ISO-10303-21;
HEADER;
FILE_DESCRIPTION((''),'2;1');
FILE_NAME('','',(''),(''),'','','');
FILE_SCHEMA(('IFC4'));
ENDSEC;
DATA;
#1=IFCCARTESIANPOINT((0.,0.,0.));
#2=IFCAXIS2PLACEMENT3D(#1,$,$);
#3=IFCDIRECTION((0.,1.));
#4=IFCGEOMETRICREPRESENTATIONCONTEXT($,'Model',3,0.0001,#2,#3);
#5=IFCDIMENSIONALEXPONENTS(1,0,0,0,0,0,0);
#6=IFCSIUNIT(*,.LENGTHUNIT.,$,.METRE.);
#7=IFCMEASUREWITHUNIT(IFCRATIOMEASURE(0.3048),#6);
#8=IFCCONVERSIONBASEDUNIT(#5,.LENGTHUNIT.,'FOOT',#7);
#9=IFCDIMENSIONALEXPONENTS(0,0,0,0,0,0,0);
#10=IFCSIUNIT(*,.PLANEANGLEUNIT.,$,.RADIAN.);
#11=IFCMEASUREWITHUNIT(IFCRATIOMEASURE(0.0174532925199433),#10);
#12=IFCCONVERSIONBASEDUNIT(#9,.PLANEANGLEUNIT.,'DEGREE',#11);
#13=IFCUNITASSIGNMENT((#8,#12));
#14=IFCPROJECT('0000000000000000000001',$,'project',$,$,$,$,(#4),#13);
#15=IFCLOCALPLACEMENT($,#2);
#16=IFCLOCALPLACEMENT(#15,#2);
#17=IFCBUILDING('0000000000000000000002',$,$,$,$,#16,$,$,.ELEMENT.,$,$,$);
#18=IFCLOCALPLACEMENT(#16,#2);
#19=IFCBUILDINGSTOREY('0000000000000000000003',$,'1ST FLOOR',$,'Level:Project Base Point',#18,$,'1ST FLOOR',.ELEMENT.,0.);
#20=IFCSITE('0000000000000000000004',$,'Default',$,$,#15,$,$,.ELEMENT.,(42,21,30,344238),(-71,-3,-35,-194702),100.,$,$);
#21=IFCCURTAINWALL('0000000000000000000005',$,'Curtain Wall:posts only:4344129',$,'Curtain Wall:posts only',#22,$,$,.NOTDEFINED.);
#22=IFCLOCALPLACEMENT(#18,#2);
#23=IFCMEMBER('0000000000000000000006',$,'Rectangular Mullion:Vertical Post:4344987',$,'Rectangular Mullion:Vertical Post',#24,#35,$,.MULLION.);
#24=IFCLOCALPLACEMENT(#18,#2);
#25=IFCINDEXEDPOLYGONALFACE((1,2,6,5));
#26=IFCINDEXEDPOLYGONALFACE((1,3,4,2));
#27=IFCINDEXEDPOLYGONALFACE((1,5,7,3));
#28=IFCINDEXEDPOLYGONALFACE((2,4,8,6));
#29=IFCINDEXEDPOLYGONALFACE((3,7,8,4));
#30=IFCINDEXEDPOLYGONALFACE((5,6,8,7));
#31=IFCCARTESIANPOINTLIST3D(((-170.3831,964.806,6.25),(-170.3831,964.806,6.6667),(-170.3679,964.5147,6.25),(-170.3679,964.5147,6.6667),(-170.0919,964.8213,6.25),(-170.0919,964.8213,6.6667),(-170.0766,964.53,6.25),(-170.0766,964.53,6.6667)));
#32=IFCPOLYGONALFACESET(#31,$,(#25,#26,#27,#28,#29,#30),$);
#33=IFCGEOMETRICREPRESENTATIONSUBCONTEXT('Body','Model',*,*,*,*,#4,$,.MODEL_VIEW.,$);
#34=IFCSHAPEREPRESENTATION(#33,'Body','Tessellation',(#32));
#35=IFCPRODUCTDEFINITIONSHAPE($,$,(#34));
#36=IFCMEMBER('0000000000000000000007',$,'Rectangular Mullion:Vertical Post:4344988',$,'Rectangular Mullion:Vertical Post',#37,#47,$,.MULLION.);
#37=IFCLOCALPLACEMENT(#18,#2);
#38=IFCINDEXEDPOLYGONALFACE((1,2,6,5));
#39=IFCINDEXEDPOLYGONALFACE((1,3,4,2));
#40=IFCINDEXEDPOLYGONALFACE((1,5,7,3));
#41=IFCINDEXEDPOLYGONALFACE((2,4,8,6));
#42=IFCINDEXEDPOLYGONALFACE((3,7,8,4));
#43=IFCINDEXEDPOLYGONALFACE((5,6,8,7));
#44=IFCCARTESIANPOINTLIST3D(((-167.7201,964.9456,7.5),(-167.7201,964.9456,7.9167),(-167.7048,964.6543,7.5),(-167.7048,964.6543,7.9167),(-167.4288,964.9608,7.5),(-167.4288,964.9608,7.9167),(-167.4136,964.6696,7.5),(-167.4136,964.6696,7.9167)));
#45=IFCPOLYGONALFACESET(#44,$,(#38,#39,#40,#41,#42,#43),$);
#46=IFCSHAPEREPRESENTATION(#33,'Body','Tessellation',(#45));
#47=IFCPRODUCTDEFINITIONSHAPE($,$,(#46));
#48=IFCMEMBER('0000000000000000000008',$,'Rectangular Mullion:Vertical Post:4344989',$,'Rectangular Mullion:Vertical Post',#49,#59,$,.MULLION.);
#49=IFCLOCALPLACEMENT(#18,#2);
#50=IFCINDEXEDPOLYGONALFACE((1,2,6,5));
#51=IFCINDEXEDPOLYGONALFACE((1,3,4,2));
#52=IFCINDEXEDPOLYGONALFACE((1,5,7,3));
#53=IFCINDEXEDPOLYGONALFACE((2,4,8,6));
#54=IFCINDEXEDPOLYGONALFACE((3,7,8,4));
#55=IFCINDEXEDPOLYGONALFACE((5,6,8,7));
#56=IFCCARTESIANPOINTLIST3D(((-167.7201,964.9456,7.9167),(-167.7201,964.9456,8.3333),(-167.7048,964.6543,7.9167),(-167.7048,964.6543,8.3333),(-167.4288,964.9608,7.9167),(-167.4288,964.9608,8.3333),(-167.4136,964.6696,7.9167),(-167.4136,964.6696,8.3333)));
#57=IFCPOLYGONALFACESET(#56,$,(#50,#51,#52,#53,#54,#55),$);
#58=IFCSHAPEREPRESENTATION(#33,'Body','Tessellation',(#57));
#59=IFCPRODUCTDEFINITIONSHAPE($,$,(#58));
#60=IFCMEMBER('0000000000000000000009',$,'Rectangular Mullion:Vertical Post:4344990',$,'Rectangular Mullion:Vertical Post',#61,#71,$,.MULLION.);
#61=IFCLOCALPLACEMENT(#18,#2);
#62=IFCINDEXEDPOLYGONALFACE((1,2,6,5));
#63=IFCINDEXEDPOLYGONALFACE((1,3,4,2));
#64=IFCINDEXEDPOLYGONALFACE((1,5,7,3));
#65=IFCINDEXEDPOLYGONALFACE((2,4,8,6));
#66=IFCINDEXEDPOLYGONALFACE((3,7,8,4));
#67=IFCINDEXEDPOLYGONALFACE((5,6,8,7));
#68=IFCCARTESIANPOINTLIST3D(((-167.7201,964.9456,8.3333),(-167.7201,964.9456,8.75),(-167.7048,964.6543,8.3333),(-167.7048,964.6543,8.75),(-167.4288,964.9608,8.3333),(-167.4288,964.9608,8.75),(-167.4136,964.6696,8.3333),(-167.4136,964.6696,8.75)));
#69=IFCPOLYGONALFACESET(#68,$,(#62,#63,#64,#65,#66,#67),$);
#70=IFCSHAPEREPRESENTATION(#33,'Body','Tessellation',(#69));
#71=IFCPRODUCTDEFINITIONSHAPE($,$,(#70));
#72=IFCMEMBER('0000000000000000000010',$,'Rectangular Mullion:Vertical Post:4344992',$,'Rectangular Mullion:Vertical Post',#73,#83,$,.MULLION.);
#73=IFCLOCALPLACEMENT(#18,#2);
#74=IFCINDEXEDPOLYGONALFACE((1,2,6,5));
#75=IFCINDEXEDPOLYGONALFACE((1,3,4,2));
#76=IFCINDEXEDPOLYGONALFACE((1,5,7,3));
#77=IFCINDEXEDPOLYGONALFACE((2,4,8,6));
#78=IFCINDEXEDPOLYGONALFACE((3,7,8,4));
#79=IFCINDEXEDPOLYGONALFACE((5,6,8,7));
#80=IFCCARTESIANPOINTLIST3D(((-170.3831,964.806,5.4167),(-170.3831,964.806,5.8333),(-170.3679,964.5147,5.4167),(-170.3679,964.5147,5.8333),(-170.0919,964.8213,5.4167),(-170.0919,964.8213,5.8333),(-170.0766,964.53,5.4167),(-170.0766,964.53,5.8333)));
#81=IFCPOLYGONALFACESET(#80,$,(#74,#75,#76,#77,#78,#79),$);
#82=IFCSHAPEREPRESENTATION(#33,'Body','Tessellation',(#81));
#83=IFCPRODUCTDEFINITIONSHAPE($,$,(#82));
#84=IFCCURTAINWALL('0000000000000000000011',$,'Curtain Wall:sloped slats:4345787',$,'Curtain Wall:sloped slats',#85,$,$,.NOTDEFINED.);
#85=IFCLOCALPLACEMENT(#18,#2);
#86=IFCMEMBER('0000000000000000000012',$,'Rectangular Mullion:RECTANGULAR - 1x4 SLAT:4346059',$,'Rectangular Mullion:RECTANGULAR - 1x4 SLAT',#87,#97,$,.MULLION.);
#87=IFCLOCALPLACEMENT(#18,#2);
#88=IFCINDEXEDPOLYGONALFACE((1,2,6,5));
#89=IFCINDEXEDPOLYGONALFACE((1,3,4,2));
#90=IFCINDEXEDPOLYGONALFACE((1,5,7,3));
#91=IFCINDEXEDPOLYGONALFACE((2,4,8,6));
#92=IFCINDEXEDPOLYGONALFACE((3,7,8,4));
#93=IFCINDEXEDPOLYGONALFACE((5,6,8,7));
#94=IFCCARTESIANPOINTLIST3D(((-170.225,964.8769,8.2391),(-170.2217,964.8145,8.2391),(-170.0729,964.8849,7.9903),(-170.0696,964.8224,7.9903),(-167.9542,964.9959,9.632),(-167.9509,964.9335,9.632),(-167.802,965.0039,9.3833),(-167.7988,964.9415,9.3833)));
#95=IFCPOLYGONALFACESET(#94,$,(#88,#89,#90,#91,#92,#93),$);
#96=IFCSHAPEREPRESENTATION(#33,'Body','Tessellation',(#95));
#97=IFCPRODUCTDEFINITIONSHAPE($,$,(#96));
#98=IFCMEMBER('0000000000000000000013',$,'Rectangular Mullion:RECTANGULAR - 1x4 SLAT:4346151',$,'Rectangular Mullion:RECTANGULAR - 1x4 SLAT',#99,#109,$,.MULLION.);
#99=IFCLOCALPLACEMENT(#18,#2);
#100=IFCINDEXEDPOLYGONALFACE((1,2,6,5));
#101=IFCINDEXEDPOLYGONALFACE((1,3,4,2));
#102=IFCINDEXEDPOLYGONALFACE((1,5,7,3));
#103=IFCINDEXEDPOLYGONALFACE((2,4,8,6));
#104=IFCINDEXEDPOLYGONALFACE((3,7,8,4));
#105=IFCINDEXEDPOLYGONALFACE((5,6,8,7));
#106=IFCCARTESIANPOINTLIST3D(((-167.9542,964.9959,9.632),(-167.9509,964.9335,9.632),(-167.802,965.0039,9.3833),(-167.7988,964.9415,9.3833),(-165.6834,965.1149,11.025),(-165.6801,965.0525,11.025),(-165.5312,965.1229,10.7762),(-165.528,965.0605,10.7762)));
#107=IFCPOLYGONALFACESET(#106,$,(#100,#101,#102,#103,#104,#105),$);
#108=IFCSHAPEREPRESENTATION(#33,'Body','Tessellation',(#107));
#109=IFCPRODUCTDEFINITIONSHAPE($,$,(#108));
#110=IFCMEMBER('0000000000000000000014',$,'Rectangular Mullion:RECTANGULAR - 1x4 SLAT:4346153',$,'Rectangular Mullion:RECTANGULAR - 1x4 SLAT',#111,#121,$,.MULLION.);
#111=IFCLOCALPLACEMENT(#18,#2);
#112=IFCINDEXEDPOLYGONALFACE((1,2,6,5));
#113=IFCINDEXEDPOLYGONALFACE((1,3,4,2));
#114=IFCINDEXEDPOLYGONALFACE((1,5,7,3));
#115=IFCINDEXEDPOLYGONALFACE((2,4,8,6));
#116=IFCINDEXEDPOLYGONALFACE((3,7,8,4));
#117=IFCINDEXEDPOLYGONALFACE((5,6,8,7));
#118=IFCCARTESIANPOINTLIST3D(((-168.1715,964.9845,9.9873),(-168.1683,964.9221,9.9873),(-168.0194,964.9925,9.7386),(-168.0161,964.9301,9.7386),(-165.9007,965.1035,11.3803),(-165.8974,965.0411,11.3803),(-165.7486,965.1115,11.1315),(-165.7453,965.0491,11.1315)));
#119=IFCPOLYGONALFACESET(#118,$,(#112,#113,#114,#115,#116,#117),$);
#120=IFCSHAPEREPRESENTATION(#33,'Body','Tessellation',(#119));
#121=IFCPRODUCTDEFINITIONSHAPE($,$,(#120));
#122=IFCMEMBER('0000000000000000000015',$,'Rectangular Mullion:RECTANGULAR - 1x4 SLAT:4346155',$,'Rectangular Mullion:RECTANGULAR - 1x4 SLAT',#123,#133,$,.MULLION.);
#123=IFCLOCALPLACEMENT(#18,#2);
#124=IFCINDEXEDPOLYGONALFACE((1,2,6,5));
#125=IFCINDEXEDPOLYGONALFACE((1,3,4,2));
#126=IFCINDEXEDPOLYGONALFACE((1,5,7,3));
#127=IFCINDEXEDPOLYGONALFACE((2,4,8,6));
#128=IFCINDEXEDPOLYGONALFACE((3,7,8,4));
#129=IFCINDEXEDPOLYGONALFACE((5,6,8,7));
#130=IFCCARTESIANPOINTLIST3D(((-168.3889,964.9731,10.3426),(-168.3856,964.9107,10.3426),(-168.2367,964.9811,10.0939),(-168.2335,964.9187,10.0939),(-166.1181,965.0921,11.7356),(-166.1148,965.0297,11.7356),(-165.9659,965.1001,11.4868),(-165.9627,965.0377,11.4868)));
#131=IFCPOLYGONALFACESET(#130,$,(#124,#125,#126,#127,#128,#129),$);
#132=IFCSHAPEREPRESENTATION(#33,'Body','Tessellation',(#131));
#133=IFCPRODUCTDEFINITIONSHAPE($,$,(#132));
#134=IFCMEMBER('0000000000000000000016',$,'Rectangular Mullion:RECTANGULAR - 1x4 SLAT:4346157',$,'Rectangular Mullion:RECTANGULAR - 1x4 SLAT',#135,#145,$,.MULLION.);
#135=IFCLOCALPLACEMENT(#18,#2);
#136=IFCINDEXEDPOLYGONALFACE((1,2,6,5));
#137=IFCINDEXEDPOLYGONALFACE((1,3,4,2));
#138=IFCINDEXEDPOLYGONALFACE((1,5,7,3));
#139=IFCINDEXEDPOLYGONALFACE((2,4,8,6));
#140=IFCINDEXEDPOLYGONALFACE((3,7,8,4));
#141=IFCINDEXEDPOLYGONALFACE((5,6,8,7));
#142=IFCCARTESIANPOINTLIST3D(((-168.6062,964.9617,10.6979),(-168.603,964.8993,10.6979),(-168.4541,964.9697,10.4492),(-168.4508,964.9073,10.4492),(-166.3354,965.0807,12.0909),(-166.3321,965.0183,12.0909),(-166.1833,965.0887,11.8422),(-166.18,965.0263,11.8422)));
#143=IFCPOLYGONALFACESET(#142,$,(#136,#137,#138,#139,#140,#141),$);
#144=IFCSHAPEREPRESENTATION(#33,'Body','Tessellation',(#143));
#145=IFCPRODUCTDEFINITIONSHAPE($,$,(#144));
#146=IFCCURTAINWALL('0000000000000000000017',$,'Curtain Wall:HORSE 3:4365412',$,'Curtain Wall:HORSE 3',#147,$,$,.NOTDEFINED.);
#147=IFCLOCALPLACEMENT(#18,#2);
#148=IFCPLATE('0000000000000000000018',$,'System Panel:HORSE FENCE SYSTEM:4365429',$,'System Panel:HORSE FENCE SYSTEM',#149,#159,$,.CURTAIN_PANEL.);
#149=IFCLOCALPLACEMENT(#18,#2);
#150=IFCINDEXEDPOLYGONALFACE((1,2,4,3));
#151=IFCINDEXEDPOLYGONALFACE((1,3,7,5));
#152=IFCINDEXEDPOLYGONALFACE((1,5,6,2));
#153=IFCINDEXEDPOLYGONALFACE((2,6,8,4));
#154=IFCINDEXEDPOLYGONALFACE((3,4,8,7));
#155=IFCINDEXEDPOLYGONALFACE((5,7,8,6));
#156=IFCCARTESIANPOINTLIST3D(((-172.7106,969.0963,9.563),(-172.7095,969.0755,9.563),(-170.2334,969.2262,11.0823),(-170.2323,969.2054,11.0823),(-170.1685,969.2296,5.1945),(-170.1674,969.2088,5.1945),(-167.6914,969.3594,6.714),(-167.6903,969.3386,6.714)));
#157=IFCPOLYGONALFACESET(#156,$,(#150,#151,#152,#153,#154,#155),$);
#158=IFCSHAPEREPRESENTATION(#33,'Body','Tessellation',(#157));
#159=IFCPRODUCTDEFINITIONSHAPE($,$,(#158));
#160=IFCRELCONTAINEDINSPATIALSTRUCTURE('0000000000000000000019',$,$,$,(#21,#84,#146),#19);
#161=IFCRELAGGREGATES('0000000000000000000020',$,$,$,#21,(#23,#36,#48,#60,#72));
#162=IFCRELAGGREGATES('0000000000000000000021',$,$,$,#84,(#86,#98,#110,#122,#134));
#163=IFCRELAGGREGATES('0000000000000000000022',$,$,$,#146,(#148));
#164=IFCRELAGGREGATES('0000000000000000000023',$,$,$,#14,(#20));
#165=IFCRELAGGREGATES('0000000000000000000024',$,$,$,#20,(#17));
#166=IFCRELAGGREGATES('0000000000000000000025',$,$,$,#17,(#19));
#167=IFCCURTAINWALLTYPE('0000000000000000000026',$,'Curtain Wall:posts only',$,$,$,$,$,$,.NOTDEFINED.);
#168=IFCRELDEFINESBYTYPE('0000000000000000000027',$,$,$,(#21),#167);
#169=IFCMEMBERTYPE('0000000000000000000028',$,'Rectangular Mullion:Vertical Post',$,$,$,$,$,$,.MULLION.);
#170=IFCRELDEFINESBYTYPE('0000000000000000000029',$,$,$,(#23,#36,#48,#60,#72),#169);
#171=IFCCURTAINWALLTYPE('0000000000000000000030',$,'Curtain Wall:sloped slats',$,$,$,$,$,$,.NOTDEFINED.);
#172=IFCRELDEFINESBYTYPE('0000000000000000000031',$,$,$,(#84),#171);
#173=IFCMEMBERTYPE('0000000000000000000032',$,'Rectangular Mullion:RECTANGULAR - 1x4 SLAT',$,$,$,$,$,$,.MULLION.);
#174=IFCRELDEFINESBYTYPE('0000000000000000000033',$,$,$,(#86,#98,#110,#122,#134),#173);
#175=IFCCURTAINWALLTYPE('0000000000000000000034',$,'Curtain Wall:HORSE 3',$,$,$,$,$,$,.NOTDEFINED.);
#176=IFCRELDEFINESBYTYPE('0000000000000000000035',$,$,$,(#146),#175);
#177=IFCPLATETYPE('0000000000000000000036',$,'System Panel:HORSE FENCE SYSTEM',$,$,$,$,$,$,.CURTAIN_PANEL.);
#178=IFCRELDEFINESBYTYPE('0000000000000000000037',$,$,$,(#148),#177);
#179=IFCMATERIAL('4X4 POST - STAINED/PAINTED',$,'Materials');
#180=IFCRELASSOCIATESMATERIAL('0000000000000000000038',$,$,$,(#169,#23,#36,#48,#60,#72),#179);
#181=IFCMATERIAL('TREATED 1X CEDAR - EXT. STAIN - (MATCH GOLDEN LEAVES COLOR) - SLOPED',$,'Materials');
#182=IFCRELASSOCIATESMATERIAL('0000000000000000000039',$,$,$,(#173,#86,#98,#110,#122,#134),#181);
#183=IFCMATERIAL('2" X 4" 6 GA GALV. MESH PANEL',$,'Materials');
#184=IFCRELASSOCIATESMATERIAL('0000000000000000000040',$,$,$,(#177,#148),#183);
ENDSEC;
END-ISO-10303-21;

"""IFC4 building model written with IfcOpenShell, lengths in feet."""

from ifc_helpers import new_model, entity, si_unit, converted_unit, direction, frame, frame_2d, origin, origin_2d_with_axis, place, context, subcontext, project, spatial, polyline, rectangle, outline, extrude, source, transform, mapped, material, material_profile, profile_set, profile_usage, type_object, type_shapes, element, aggregate, save


model = new_model("IFC4")

# Units and contexts
model_context = context("Model", 3, precision=0.0001, world=origin(), true_north=direction((0.0, 1.0)))
body_context = subcontext(model_context, "Body", "Model", "MODEL_VIEW")
ifc_project = project(units=[converted_unit("LENGTHUNIT", "FOOT", entity("IfcRatioMeasure", 0.3048), si_unit("LENGTHUNIT", "METRE"), dimensions=[1, 0, 0, 0, 0, 0, 0]), converted_unit("PLANEANGLEUNIT", "DEGREE", entity("IfcRatioMeasure", 0.0174532925199433), si_unit("PLANEANGLEUNIT", "RADIAN"), dimensions=[0, 0, 0, 0, 0, 0, 0])], contexts=[model_context])

# Site, building, storey
site_placement = place(None, origin())
site = spatial("IfcSite", under=ifc_project, at=site_placement, Name="Default", CompositionType="ELEMENT", RefLatitude=(42, 21, 30, 344238), RefLongitude=(-71, -3, -35, -194702), RefElevation=100.0)
building_placement = place(site_placement, origin())
building = spatial("IfcBuilding", under=site, at=building_placement, CompositionType="ELEMENT")
storey_placement = place(building_placement, origin())
storey = spatial("IfcBuildingStorey", under=building, at=storey_placement, Name="1ST FLOOR", ObjectType="Level:Project Base Point", LongName="1ST FLOOR", CompositionType="ELEMENT", Elevation=0.0)

# Curtain walls, members
curtain_wall_type_1 = type_object("IfcCurtainWallType", Name="Curtain Wall:posts only", PredefinedType="NOTDEFINED")
curtain_wall_1_placement = place(storey_placement, origin())
curtain_wall_1 = element("IfcCurtainWall", 1, at=curtain_wall_1_placement, inside=storey, type_object=curtain_wall_type_1, Name="Curtain Wall:posts only:4344129", ObjectType="Curtain Wall:posts only", PredefinedType="NOTDEFINED")
ifc_material_1 = material(Name="4X4 POST - STAINED/PAINTED", Category="Materials")
ifc_material_profile_1 = material_profile(ifc_material_1, rectangle(XDim=0.2917, YDim=0.2917, at=origin_2d_with_axis()), Name="Vertical Post")
ifc_profile_set_1 = profile_set([ifc_material_profile_1], Name="Vertical Post")
member_type_1 = type_object("IfcMemberType", Name="Rectangular Mullion:Vertical Post", PredefinedType="MULLION", material=ifc_profile_set_1)
shared_shape_1 = source(origin(), body_context, "Body", "SweptSolid", [
    extrude(rectangle(XDim=0.2917, YDim=0.2917, at=origin_2d_with_axis()), frame((0.0, -0.2083, -0.4167), z_axis=(0.0, 0.0, 1.0), x_axis=(0.0, -1.0, 0.0)), (0.0, 0.0, 1.0), 0.4167),
])
type_shapes(member_type_1, [shared_shape_1])
ifc_profile_usage_1 = profile_usage(ifc_profile_set_1)
member_1_placement = place(storey_placement, frame((-170.2408, 964.8761, 6.25), z_axis=(0.0, 0.0, -1.0), x_axis=(-0.99863, -0.052336, 0.0)))
member_1 = element("IfcMember", 2, at=member_1_placement, type_object=member_type_1, material=ifc_profile_usage_1, Name="Rectangular Mullion:Vertical Post:4344987", ObjectType="Rectangular Mullion:Vertical Post", PredefinedType="MULLION", context=body_context, shape_type="MappedRepresentation", body=[
    mapped(shared_shape_1, transform((0.0, 0.0, 0.0), scale=1.0)),
])
ifc_profile_usage_2 = profile_usage(ifc_profile_set_1)
member_2_placement = place(storey_placement, frame((-167.5777, 965.0156, 7.5), z_axis=(0.0, 0.0, -1.0), x_axis=(-0.99863, -0.052336, 0.0)))
member_2 = element("IfcMember", 3, at=member_2_placement, type_object=member_type_1, material=ifc_profile_usage_2, Name="Rectangular Mullion:Vertical Post:4344988", ObjectType="Rectangular Mullion:Vertical Post", PredefinedType="MULLION", context=body_context, shape_type="MappedRepresentation", body=[
    mapped(shared_shape_1, transform((0.0, 0.0, 0.0), scale=1.0)),
])
ifc_profile_usage_3 = profile_usage(ifc_profile_set_1)
member_3_placement = place(storey_placement, frame((-167.5777, 965.0156, 7.9167), z_axis=(0.0, 0.0, -1.0), x_axis=(-0.99863, -0.052336, 0.0)))
member_3 = element("IfcMember", 4, at=member_3_placement, type_object=member_type_1, material=ifc_profile_usage_3, Name="Rectangular Mullion:Vertical Post:4344989", ObjectType="Rectangular Mullion:Vertical Post", PredefinedType="MULLION", context=body_context, shape_type="MappedRepresentation", body=[
    mapped(shared_shape_1, transform((0.0, 0.0, 0.0), scale=1.0)),
])
ifc_profile_usage_4 = profile_usage(ifc_profile_set_1)
member_4_placement = place(storey_placement, frame((-167.5777, 965.0156, 8.3333), z_axis=(0.0, 0.0, -1.0), x_axis=(-0.99863, -0.052336, 0.0)))
member_4 = element("IfcMember", 5, at=member_4_placement, type_object=member_type_1, material=ifc_profile_usage_4, Name="Rectangular Mullion:Vertical Post:4344990", ObjectType="Rectangular Mullion:Vertical Post", PredefinedType="MULLION", context=body_context, shape_type="MappedRepresentation", body=[
    mapped(shared_shape_1, transform((0.0, 0.0, 0.0), scale=1.0)),
])
ifc_profile_usage_5 = profile_usage(ifc_profile_set_1)
member_5_placement = place(storey_placement, frame((-170.2408, 964.8761, 5.4167), z_axis=(0.0, 0.0, -1.0), x_axis=(-0.99863, -0.052336, 0.0)))
member_5 = element("IfcMember", 6, at=member_5_placement, type_object=member_type_1, material=ifc_profile_usage_5, Name="Rectangular Mullion:Vertical Post:4344992", ObjectType="Rectangular Mullion:Vertical Post", PredefinedType="MULLION", context=body_context, shape_type="MappedRepresentation", body=[
    mapped(shared_shape_1, transform((0.0, 0.0, 0.0), scale=1.0)),
])
aggregate(curtain_wall_1, [member_1, member_2, member_3, member_4, member_5])
curtain_wall_type_2 = type_object("IfcCurtainWallType", Name="Curtain Wall:sloped slats", PredefinedType="NOTDEFINED")
curtain_wall_2_placement = place(storey_placement, origin())
curtain_wall_2 = element("IfcCurtainWall", 7, at=curtain_wall_2_placement, inside=storey, type_object=curtain_wall_type_2, Name="Curtain Wall:sloped slats:4345787", ObjectType="Curtain Wall:sloped slats", PredefinedType="NOTDEFINED")
ifc_material_2 = material(Name="TREATED 1X CEDAR - EXT. STAIN - (MATCH GOLDEN LEAVES COLOR) - SLOPED", Category="Materials")
ifc_material_profile_2 = material_profile(ifc_material_2, rectangle(XDim=0.0625, YDim=0.2917, at=frame_2d((0.0, 0.0), x_axis=(1.0, 0.0))), Name="RECTANGULAR - 1x4 SLAT")
ifc_profile_set_2 = profile_set([ifc_material_profile_2], Name="RECTANGULAR - 1x4 SLAT")
ifc_profile_usage_6 = profile_usage(ifc_profile_set_2)
member_type_2 = type_object("IfcMemberType", Name="Rectangular Mullion:RECTANGULAR - 1x4 SLAT", PredefinedType="MULLION", material=ifc_profile_set_2)
shared_shape_2 = source(origin(), body_context, "Body", "SweptSolid", [
    extrude(rectangle(XDim=0.0625, YDim=0.2917, at=frame_2d((0.0, 0.0), x_axis=(1.0, 0.0))), frame((0.0, 0.0, -2.6667), z_axis=(0.0, 0.0, 1.0), x_axis=(0.0, -1.0, 0.0)), (0.0, 0.0, 1.0), 2.6667),
])
type_shapes(member_type_2, [shared_shape_2])
member_6_placement = place(storey_placement, frame((-170.1473, 964.8497, 8.1147), z_axis=(-0.851559, -0.044628, -0.522356), x_axis=(-0.52164, -0.027338, 0.852727)))
member_6 = element("IfcMember", 8, at=member_6_placement, type_object=member_type_2, material=ifc_profile_usage_6, Name="Rectangular Mullion:RECTANGULAR - 1x4 SLAT:4346059", ObjectType="Rectangular Mullion:RECTANGULAR - 1x4 SLAT", PredefinedType="MULLION", context=body_context, shape_type="MappedRepresentation", body=[
    mapped(shared_shape_2, transform((0.0, 0.0, 0.0), scale=1.0)),
])
ifc_profile_usage_7 = profile_usage(ifc_profile_set_2)
member_7_placement = place(storey_placement, frame((-167.8765, 964.9687, 9.5076), z_axis=(-0.851559, -0.044628, -0.522356), x_axis=(-0.52164, -0.027338, 0.852727)))
member_7 = element("IfcMember", 9, at=member_7_placement, type_object=member_type_2, material=ifc_profile_usage_7, Name="Rectangular Mullion:RECTANGULAR - 1x4 SLAT:4346151", ObjectType="Rectangular Mullion:RECTANGULAR - 1x4 SLAT", PredefinedType="MULLION", context=body_context, shape_type="MappedRepresentation", body=[
    mapped(shared_shape_2, transform((0.0, 0.0, 0.0), scale=1.0)),
])
ifc_profile_usage_8 = profile_usage(ifc_profile_set_2)
member_8_placement = place(storey_placement, frame((-168.0938, 964.9573, 9.863), z_axis=(-0.851559, -0.044628, -0.522356), x_axis=(-0.52164, -0.027338, 0.852727)))
member_8 = element("IfcMember", 10, at=member_8_placement, type_object=member_type_2, material=ifc_profile_usage_8, Name="Rectangular Mullion:RECTANGULAR - 1x4 SLAT:4346153", ObjectType="Rectangular Mullion:RECTANGULAR - 1x4 SLAT", PredefinedType="MULLION", context=body_context, shape_type="MappedRepresentation", body=[
    mapped(shared_shape_2, transform((0.0, 0.0, 0.0), scale=1.0)),
])
ifc_profile_usage_9 = profile_usage(ifc_profile_set_2)
member_9_placement = place(storey_placement, frame((-168.3112, 964.9459, 10.2183), z_axis=(-0.851559, -0.044628, -0.522356), x_axis=(-0.52164, -0.027338, 0.852727)))
member_9 = element("IfcMember", 11, at=member_9_placement, type_object=member_type_2, material=ifc_profile_usage_9, Name="Rectangular Mullion:RECTANGULAR - 1x4 SLAT:4346155", ObjectType="Rectangular Mullion:RECTANGULAR - 1x4 SLAT", PredefinedType="MULLION", context=body_context, shape_type="MappedRepresentation", body=[
    mapped(shared_shape_2, transform((0.0, 0.0, 0.0), scale=1.0)),
])
ifc_profile_usage_10 = profile_usage(ifc_profile_set_2)
member_10_placement = place(storey_placement, frame((-168.5285, 964.9345, 10.5736), z_axis=(-0.851559, -0.044628, -0.522356), x_axis=(-0.52164, -0.027338, 0.852727)))
member_10 = element("IfcMember", 12, at=member_10_placement, type_object=member_type_2, material=ifc_profile_usage_10, Name="Rectangular Mullion:RECTANGULAR - 1x4 SLAT:4346157", ObjectType="Rectangular Mullion:RECTANGULAR - 1x4 SLAT", PredefinedType="MULLION", context=body_context, shape_type="MappedRepresentation", body=[
    mapped(shared_shape_2, transform((0.0, 0.0, 0.0), scale=1.0)),
])
aggregate(curtain_wall_2, [member_6, member_7, member_8, member_9, member_10])

# Curtain wall, plate
curtain_wall_type_3 = type_object("IfcCurtainWallType", Name="Curtain Wall:HORSE 3", PredefinedType="NOTDEFINED")
curtain_wall_3_placement = place(storey_placement, origin())
curtain_wall_3 = element("IfcCurtainWall", 13, at=curtain_wall_3_placement, inside=storey, type_object=curtain_wall_type_3, Name="Curtain Wall:HORSE 3:4365412", ObjectType="Curtain Wall:HORSE 3", PredefinedType="NOTDEFINED")
ifc_material_3 = material(Name="2\" X 4\" 6 GA GALV. MESH PANEL", Category="Materials")
plate_type = type_object("IfcPlateType", Name="System Panel:HORSE FENCE SYSTEM", PredefinedType="CURTAIN_PANEL", material=ifc_material_3)
shared_shape_3 = source(origin(), body_context, "Body", "SweptSolid", [
    extrude(outline(polyline([(-2.496, -1.4541), (2.5599, -1.4541), (2.4961, 1.4541), (-2.56, 1.4541), (-2.496, -1.4541)])), frame((1.5101, 0.0, 2.5274), z_axis=(0.0, 1.0, 0.0), x_axis=(-0.021996, 0.0, 0.999758)), (0.0, 0.0, 1.0), 0.0208),
])
type_shapes(plate_type, [shared_shape_3])
plate_placement = place(curtain_wall_3_placement, frame((-167.5967, 969.3643, 6.7721), z_axis=(-0.52164, -0.027338, 0.852728), x_axis=(-0.851559, -0.044628, -0.522356)))
plate = element("IfcPlate", 14, at=plate_placement, type_object=plate_type, material=ifc_material_3, Name="System Panel:HORSE FENCE SYSTEM:4365429", ObjectType="System Panel:HORSE FENCE SYSTEM", PredefinedType="CURTAIN_PANEL", context=body_context, shape_type="MappedRepresentation", body=[
    mapped(shared_shape_3, transform((0.0, 0.0, 0.0), scale=1.0)),
])
aggregate(curtain_wall_3, [plate])

save(model, "model.ifc")
